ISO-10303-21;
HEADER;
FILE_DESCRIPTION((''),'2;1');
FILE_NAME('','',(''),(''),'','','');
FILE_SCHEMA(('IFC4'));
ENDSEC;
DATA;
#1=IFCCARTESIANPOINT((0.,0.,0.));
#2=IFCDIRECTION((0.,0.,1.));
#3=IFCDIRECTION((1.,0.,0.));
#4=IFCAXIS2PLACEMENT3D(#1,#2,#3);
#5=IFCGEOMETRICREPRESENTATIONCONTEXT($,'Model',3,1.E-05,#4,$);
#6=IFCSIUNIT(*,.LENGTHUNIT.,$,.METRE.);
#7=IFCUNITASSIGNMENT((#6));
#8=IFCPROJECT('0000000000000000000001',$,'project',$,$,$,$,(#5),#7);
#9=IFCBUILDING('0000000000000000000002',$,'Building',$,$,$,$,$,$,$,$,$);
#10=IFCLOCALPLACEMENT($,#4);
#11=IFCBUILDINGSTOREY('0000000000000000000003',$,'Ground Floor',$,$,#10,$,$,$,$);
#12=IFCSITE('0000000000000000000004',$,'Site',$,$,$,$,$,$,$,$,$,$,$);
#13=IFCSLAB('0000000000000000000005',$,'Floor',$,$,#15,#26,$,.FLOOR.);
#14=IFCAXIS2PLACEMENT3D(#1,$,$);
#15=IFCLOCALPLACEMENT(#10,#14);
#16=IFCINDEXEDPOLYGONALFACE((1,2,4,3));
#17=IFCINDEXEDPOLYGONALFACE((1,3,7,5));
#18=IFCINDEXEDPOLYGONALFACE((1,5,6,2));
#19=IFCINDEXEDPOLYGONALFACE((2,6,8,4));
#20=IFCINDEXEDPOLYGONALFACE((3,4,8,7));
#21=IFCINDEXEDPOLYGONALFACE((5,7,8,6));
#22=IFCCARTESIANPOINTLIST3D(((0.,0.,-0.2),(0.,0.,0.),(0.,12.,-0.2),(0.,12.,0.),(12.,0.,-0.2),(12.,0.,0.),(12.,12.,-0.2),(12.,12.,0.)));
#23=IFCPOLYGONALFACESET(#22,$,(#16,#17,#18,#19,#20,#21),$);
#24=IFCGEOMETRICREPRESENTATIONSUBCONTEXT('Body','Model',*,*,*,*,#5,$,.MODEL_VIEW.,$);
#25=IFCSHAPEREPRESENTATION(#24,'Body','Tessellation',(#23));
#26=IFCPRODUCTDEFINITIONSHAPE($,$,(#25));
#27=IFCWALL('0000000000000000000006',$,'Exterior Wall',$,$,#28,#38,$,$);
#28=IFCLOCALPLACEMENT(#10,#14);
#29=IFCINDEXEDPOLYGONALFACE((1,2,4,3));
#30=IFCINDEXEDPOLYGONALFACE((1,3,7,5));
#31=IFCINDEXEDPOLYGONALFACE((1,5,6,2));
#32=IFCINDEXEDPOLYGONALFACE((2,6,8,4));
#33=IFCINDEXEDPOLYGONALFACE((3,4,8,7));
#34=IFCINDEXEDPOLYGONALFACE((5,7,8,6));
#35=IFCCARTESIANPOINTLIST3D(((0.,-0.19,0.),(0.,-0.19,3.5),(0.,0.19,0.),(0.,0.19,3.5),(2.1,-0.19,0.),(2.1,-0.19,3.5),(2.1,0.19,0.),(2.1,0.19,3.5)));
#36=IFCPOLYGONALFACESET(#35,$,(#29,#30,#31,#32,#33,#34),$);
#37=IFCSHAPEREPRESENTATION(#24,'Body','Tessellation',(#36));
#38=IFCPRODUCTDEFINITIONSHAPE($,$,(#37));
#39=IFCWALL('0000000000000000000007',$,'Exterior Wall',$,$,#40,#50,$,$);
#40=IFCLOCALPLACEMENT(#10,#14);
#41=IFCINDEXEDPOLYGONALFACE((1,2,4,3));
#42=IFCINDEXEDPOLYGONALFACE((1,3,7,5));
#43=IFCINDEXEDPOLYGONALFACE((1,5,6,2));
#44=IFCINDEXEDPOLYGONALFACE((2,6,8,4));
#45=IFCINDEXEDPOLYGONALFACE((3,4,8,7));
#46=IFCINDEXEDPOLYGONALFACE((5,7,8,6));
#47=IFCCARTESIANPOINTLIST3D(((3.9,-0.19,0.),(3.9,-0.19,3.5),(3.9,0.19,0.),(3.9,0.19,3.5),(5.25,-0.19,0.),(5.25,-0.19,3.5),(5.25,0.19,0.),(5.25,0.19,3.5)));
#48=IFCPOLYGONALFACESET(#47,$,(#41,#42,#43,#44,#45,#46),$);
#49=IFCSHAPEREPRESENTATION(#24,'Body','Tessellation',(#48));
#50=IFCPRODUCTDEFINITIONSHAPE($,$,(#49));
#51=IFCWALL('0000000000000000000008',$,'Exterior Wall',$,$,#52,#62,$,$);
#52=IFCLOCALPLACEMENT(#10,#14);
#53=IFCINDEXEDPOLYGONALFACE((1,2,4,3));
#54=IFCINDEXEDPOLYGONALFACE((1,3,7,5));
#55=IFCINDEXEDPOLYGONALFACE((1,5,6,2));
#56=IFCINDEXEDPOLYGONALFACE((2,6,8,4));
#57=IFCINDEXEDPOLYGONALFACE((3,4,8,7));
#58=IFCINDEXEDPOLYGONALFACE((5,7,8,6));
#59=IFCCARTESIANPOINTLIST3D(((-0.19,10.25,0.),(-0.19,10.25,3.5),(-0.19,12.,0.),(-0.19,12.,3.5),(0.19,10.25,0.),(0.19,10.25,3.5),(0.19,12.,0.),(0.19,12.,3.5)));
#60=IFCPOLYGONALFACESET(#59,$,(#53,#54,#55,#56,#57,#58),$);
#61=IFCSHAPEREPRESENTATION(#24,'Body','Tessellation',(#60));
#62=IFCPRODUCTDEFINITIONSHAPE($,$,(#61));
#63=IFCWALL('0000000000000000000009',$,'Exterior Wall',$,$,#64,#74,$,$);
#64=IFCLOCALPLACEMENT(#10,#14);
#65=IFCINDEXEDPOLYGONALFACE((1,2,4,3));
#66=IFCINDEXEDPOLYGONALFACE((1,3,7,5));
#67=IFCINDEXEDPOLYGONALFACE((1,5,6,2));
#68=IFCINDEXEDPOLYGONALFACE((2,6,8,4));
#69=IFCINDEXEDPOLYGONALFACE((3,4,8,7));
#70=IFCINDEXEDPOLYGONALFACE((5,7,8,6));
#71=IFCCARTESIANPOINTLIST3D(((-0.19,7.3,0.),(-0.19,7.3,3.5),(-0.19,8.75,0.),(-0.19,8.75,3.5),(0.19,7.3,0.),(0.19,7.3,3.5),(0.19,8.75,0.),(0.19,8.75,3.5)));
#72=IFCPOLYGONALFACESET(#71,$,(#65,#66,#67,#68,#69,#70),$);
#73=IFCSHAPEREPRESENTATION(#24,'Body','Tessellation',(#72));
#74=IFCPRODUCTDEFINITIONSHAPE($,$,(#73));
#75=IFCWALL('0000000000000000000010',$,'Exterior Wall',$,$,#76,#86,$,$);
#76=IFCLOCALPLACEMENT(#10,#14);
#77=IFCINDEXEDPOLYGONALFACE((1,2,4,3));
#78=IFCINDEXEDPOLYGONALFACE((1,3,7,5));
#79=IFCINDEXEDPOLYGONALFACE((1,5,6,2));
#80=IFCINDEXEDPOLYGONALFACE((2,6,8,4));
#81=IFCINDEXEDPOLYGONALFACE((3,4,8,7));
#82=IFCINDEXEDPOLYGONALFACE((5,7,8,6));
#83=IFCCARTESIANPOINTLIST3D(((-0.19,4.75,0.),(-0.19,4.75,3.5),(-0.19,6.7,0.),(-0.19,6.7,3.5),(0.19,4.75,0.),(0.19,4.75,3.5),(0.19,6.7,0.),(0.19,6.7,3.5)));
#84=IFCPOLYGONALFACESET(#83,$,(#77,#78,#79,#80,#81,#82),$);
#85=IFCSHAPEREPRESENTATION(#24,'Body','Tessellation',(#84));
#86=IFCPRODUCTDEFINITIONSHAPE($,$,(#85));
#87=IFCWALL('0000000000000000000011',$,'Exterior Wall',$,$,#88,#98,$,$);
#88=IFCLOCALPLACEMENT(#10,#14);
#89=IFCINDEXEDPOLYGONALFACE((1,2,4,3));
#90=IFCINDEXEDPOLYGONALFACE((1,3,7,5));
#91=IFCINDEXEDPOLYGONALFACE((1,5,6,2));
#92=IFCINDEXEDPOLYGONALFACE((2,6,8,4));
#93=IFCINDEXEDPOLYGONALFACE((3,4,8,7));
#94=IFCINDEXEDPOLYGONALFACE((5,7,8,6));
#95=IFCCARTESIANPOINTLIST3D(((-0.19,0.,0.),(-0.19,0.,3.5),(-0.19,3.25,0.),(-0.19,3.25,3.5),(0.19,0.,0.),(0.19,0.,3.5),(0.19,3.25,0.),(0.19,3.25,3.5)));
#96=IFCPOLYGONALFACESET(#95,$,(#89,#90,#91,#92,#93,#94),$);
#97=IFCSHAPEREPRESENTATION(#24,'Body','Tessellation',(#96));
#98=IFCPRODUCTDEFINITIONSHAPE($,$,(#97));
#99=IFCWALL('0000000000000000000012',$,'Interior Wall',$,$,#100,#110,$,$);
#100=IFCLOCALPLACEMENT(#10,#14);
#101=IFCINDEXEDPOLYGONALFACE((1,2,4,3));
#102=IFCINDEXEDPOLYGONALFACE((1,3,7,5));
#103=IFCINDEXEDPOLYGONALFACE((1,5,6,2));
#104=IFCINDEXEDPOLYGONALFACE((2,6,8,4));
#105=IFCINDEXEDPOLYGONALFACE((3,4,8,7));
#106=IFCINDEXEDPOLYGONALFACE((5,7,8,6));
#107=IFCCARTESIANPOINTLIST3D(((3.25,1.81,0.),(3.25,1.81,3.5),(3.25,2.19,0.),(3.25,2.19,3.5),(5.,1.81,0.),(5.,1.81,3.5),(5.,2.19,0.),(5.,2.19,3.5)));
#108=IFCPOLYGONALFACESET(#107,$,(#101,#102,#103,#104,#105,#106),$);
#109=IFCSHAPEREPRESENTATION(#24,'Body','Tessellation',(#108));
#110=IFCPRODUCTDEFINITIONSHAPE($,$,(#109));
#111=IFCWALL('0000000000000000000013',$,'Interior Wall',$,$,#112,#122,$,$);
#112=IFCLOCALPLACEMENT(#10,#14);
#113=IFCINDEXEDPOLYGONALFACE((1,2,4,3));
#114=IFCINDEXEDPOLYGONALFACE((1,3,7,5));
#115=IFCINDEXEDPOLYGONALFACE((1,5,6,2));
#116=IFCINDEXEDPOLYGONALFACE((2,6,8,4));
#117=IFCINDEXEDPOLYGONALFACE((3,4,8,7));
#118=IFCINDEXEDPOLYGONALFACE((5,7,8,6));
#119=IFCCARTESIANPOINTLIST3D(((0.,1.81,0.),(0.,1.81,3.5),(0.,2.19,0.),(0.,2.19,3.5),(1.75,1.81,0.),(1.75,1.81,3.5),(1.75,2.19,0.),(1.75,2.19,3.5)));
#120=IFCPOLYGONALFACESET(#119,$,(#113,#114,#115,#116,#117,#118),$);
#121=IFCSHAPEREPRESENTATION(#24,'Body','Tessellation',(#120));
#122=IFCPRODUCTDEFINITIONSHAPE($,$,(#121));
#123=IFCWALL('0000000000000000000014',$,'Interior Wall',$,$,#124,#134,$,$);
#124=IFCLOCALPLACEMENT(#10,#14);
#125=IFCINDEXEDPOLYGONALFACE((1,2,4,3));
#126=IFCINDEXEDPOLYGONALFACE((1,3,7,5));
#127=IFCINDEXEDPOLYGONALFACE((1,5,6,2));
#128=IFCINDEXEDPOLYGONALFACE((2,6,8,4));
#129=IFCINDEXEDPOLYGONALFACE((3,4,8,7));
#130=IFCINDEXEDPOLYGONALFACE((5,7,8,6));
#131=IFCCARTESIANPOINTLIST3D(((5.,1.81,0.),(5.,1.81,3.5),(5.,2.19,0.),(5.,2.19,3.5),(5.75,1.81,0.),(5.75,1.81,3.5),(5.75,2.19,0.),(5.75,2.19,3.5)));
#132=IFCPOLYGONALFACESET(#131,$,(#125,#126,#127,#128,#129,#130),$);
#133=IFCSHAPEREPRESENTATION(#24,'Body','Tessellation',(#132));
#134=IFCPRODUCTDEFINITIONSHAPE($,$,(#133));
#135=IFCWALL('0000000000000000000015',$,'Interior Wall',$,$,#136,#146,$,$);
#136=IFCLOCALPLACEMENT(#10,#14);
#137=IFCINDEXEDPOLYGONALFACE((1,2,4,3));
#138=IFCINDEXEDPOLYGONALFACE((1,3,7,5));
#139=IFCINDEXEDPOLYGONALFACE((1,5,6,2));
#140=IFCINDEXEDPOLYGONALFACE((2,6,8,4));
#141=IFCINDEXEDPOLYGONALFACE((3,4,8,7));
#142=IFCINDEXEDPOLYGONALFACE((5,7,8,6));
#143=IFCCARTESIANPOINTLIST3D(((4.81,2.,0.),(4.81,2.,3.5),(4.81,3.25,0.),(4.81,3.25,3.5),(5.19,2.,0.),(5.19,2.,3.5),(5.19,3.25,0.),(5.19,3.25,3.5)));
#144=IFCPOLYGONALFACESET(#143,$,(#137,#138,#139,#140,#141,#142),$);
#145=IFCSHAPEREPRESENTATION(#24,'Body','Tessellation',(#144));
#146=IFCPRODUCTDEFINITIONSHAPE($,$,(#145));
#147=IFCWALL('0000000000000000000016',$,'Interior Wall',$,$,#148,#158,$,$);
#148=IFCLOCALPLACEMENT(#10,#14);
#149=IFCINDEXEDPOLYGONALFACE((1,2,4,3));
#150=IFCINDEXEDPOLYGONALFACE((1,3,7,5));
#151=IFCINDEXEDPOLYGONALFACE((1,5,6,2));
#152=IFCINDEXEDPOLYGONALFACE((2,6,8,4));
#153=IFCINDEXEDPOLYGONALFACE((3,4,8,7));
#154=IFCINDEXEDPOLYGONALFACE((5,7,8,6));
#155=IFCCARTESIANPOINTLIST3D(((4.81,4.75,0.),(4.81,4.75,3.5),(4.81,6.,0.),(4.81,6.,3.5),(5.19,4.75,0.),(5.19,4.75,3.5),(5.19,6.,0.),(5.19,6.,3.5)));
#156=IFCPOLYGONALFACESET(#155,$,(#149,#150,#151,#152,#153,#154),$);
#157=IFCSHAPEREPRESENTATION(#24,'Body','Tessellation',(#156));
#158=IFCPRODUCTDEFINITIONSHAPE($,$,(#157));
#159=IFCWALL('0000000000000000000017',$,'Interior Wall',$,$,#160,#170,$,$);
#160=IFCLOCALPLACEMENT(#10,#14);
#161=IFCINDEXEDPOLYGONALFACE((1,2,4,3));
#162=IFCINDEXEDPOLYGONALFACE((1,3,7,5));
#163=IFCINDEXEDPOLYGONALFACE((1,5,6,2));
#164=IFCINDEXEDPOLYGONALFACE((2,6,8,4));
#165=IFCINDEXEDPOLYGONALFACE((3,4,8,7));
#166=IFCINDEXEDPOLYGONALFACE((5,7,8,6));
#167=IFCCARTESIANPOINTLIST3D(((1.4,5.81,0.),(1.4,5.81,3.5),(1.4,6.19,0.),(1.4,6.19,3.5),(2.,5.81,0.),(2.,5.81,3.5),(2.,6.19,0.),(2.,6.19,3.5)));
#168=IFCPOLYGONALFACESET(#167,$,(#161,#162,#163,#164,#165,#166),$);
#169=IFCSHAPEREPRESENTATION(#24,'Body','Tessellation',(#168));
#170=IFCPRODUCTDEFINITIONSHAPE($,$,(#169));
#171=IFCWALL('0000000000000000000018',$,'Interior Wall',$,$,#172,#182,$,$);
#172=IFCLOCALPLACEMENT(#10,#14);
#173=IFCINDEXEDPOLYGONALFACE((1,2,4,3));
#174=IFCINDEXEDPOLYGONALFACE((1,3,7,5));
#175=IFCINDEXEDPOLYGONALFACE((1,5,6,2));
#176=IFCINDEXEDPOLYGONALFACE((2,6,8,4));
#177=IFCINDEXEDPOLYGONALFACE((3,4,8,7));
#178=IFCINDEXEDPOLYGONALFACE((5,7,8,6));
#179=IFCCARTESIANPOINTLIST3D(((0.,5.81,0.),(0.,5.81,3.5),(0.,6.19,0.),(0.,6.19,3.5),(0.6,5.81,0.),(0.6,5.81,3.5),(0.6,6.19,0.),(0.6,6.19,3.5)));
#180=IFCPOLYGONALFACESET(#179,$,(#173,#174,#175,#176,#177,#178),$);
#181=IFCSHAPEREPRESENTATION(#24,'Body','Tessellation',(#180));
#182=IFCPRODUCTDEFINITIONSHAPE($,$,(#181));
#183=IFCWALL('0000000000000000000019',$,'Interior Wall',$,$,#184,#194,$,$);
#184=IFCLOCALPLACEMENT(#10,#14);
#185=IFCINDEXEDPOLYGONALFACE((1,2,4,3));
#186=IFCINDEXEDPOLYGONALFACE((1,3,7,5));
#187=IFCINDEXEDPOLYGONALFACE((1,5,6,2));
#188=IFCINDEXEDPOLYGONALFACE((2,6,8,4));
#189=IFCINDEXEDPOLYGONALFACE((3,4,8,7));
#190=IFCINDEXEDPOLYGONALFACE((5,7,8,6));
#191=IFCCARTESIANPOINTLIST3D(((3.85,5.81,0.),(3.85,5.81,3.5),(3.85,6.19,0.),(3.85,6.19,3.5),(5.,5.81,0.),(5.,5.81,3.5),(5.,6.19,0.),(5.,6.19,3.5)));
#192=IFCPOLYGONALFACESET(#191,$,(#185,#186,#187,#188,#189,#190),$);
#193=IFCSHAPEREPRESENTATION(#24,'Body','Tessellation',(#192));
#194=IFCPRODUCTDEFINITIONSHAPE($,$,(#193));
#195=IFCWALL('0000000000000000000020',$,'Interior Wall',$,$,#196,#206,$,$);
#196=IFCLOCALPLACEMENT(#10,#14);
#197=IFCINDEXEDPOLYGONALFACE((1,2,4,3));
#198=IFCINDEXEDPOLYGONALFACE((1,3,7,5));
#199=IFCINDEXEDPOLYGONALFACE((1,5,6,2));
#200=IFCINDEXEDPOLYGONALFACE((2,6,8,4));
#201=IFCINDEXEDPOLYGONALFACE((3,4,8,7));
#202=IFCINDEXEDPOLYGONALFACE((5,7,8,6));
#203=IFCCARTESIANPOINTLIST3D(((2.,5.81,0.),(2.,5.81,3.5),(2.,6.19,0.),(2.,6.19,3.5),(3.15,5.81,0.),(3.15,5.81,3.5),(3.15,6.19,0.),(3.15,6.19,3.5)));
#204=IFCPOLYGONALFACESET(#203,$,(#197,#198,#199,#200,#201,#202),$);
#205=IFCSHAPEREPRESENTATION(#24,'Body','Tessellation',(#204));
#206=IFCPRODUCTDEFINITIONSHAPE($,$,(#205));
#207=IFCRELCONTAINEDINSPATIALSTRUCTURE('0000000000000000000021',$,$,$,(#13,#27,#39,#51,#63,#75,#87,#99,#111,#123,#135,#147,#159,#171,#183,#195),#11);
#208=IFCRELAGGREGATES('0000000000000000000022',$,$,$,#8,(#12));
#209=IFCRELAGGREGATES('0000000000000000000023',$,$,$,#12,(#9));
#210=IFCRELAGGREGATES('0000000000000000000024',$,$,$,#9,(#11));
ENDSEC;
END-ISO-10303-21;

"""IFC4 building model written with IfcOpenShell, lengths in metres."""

from ifc_helpers import new_model, si_unit, frame, origin_with_axes, place, context, subcontext, project, spatial, indexed_curve, outline, extrude, element, save


model = new_model("IFC4")

# Units and contexts
model_context = context("Model", 3, precision=1e-05, world=origin_with_axes())
body_context = subcontext(model_context, "Body", "Model", "MODEL_VIEW")
ifc_project = project(units=[si_unit("LENGTHUNIT", "METRE")], contexts=[model_context])

# Site, building, storey
site = spatial("IfcSite", under=ifc_project, Name="Site")
building = spatial("IfcBuilding", under=site, Name="Building")
storey_placement = place(None, origin_with_axes())
storey = spatial("IfcBuildingStorey", under=building, at=storey_placement, Name="Ground Floor")

# Slab
slab_placement = place(storey_placement, frame((0.0, 0.0, -0.2), z_axis=(0.0, 0.0, 1.0), x_axis=(1.0, 0.0, 0.0)))
element("IfcSlab", 1, at=slab_placement, inside=storey, Name="Floor", PredefinedType="FLOOR", context=body_context, shape_type="SweptSolid", body=[
    extrude(outline(indexed_curve([(0.0, 0.0), (12.0, 0.0), (12.0, 12.0), (0.0, 12.0)])), None, (0.0, 0.0, 1.0), 0.2),
])

# Walls
wall_1_placement = place(storey_placement, origin_with_axes())
element("IfcWall", 2, at=wall_1_placement, inside=storey, Name="Exterior Wall", context=body_context, shape_type="SweptSolid", body=[
    extrude(outline(indexed_curve([(0.0, 0.0), (0.0, 0.38), (2.1, 0.38), (2.1, 0.0), (0.0, 0.0)], self_intersect=False)), frame((0.0, -0.19, 0.0), z_axis=(0.0, 0.0, 1.0), x_axis=(1.0, 0.0, 0.0)), (0.0, 0.0, 1.0), 3.5),
])
wall_2_placement = place(storey_placement, frame((3.9, 0.0, 0.0), z_axis=(0.0, 0.0, 1.0), x_axis=(1.0, 0.0, 0.0)))
element("IfcWall", 3, at=wall_2_placement, inside=storey, Name="Exterior Wall", context=body_context, shape_type="SweptSolid", body=[
    extrude(outline(indexed_curve([(0.0, 0.0), (0.0, 0.38), (1.35, 0.38), (1.35, 0.0), (0.0, 0.0)], self_intersect=False)), frame((0.0, -0.19, 0.0), z_axis=(0.0, 0.0, 1.0), x_axis=(1.0, 0.0, 0.0)), (0.0, 0.0, 1.0), 3.5),
])
wall_3_placement = place(storey_placement, frame((0.0, 12.0, 0.0), z_axis=(0.0, 0.0, 1.0), x_axis=(0.0, -1.0, 0.0)))
element("IfcWall", 4, at=wall_3_placement, inside=storey, Name="Exterior Wall", context=body_context, shape_type="SweptSolid", body=[
    extrude(outline(indexed_curve([(0.0, 0.0), (0.0, 0.38), (1.75, 0.38), (1.75, 0.0), (0.0, 0.0)], self_intersect=False)), frame((0.0, -0.19, 0.0), z_axis=(0.0, 0.0, 1.0), x_axis=(1.0, 0.0, 0.0)), (0.0, 0.0, 1.0), 3.5),
])
wall_4_placement = place(storey_placement, frame((0.0, 8.75, 0.0), z_axis=(0.0, 0.0, 1.0), x_axis=(0.0, -1.0, 0.0)))
element("IfcWall", 5, at=wall_4_placement, inside=storey, Name="Exterior Wall", context=body_context, shape_type="SweptSolid", body=[
    extrude(outline(indexed_curve([(0.0, 0.0), (0.0, 0.38), (1.45, 0.38), (1.45, 0.0), (0.0, 0.0)], self_intersect=False)), frame((0.0, -0.19, 0.0), z_axis=(0.0, 0.0, 1.0), x_axis=(1.0, 0.0, 0.0)), (0.0, 0.0, 1.0), 3.5),
])
wall_5_placement = place(storey_placement, frame((0.0, 6.7, 0.0), z_axis=(0.0, 0.0, 1.0), x_axis=(0.0, -1.0, 0.0)))
element("IfcWall", 6, at=wall_5_placement, inside=storey, Name="Exterior Wall", context=body_context, shape_type="SweptSolid", body=[
    extrude(outline(indexed_curve([(0.0, 0.0), (0.0, 0.38), (1.95, 0.38), (1.95, 0.0), (0.0, 0.0)], self_intersect=False)), frame((0.0, -0.19, 0.0), z_axis=(0.0, 0.0, 1.0), x_axis=(1.0, 0.0, 0.0)), (0.0, 0.0, 1.0), 3.5),
])
wall_6_placement = place(storey_placement, frame((0.0, 3.25, 0.0), z_axis=(0.0, 0.0, 1.0), x_axis=(0.0, -1.0, 0.0)))
element("IfcWall", 7, at=wall_6_placement, inside=storey, Name="Exterior Wall", context=body_context, shape_type="SweptSolid", body=[
    extrude(outline(indexed_curve([(0.0, 0.0), (0.0, 0.38), (3.25, 0.38), (3.25, 0.0), (0.0, 0.0)], self_intersect=False)), frame((0.0, -0.19, 0.0), z_axis=(0.0, 0.0, 1.0), x_axis=(1.0, 0.0, 0.0)), (0.0, 0.0, 1.0), 3.5),
])
for number, where, z_axis, x_axis, name in (
    (8, (5.0, 2.0, 0.0), (0.0, 0.0, 1.0), (-1.0, 0.0, 0.0), "Interior Wall"),
    (9, (1.75, 2.0, 0.0), (0.0, 0.0, 1.0), (-1.0, 0.0, 0.0), "Interior Wall"),
):
    element("IfcWall", number, at=place(storey_placement, frame(where, z_axis=z_axis, x_axis=x_axis)), inside=storey, Name=name, context=body_context, shape_type="SweptSolid", body=[
        extrude(outline(indexed_curve([(0.0, 0.0), (0.0, 0.38), (1.75, 0.38), (1.75, 0.0), (0.0, 0.0)], self_intersect=False)), frame((0.0, -0.19, 0.0), z_axis=(0.0, 0.0, 1.0), x_axis=(1.0, 0.0, 0.0)), (0.0, 0.0, 1.0), 3.5),
    ])
wall_7_placement = place(storey_placement, frame((5.75, 2.0, 0.0), z_axis=(0.0, 0.0, 1.0), x_axis=(-1.0, 0.0, 0.0)))
element("IfcWall", 10, at=wall_7_placement, inside=storey, Name="Interior Wall", context=body_context, shape_type="SweptSolid", body=[
    extrude(outline(indexed_curve([(0.0, 0.0), (0.0, 0.38), (0.75, 0.38), (0.75, 0.0), (0.0, 0.0)], self_intersect=False)), frame((0.0, -0.19, 0.0), z_axis=(0.0, 0.0, 1.0), x_axis=(1.0, 0.0, 0.0)), (0.0, 0.0, 1.0), 3.5),
])
for number, where, z_axis, x_axis, name in (
    (11, (5.0, 2.0, 0.0), (0.0, 0.0, 1.0), (0.0, 1.0, 0.0), "Interior Wall"),
    (12, (5.0, 4.75, 0.0), (0.0, 0.0, 1.0), (0.0, 1.0, 0.0), "Interior Wall"),
):
    element("IfcWall", number, at=place(storey_placement, frame(where, z_axis=z_axis, x_axis=x_axis)), inside=storey, Name=name, context=body_context, shape_type="SweptSolid", body=[
        extrude(outline(indexed_curve([(0.0, 0.0), (0.0, 0.38), (1.25, 0.38), (1.25, 0.0), (0.0, 0.0)], self_intersect=False)), frame((0.0, -0.19, 0.0), z_axis=(0.0, 0.0, 1.0), x_axis=(1.0, 0.0, 0.0)), (0.0, 0.0, 1.0), 3.5),
    ])
for number, where, z_axis, x_axis, name in (
    (13, (2.0, 6.0, 0.0), (0.0, 0.0, 1.0), (-1.0, 0.0, 0.0), "Interior Wall"),
    (14, (0.6, 6.0, 0.0), (0.0, 0.0, 1.0), (-1.0, 0.0, 0.0), "Interior Wall"),
):
    element("IfcWall", number, at=place(storey_placement, frame(where, z_axis=z_axis, x_axis=x_axis)), inside=storey, Name=name, context=body_context, shape_type="SweptSolid", body=[
        extrude(outline(indexed_curve([(0.0, 0.0), (0.0, 0.38), (0.6, 0.38), (0.6, 0.0), (0.0, 0.0)], self_intersect=False)), frame((0.0, -0.19, 0.0), z_axis=(0.0, 0.0, 1.0), x_axis=(1.0, 0.0, 0.0)), (0.0, 0.0, 1.0), 3.5),
    ])
for number, where, z_axis, x_axis, name in (
    (15, (5.0, 6.0, 0.0), (0.0, 0.0, 1.0), (-1.0, 0.0, 0.0), "Interior Wall"),
    (16, (3.15, 6.0, 0.0), (0.0, 0.0, 1.0), (-1.0, 0.0, 0.0), "Interior Wall"),
):
    element("IfcWall", number, at=place(storey_placement, frame(where, z_axis=z_axis, x_axis=x_axis)), inside=storey, Name=name, context=body_context, shape_type="SweptSolid", body=[
        extrude(outline(indexed_curve([(0.0, 0.0), (0.0, 0.38), (1.15, 0.38), (1.15, 0.0), (0.0, 0.0)], self_intersect=False)), frame((0.0, -0.19, 0.0), z_axis=(0.0, 0.0, 1.0), x_axis=(1.0, 0.0, 0.0)), (0.0, 0.0, 1.0), 3.5),
    ])

save(model, "model.ifc")
